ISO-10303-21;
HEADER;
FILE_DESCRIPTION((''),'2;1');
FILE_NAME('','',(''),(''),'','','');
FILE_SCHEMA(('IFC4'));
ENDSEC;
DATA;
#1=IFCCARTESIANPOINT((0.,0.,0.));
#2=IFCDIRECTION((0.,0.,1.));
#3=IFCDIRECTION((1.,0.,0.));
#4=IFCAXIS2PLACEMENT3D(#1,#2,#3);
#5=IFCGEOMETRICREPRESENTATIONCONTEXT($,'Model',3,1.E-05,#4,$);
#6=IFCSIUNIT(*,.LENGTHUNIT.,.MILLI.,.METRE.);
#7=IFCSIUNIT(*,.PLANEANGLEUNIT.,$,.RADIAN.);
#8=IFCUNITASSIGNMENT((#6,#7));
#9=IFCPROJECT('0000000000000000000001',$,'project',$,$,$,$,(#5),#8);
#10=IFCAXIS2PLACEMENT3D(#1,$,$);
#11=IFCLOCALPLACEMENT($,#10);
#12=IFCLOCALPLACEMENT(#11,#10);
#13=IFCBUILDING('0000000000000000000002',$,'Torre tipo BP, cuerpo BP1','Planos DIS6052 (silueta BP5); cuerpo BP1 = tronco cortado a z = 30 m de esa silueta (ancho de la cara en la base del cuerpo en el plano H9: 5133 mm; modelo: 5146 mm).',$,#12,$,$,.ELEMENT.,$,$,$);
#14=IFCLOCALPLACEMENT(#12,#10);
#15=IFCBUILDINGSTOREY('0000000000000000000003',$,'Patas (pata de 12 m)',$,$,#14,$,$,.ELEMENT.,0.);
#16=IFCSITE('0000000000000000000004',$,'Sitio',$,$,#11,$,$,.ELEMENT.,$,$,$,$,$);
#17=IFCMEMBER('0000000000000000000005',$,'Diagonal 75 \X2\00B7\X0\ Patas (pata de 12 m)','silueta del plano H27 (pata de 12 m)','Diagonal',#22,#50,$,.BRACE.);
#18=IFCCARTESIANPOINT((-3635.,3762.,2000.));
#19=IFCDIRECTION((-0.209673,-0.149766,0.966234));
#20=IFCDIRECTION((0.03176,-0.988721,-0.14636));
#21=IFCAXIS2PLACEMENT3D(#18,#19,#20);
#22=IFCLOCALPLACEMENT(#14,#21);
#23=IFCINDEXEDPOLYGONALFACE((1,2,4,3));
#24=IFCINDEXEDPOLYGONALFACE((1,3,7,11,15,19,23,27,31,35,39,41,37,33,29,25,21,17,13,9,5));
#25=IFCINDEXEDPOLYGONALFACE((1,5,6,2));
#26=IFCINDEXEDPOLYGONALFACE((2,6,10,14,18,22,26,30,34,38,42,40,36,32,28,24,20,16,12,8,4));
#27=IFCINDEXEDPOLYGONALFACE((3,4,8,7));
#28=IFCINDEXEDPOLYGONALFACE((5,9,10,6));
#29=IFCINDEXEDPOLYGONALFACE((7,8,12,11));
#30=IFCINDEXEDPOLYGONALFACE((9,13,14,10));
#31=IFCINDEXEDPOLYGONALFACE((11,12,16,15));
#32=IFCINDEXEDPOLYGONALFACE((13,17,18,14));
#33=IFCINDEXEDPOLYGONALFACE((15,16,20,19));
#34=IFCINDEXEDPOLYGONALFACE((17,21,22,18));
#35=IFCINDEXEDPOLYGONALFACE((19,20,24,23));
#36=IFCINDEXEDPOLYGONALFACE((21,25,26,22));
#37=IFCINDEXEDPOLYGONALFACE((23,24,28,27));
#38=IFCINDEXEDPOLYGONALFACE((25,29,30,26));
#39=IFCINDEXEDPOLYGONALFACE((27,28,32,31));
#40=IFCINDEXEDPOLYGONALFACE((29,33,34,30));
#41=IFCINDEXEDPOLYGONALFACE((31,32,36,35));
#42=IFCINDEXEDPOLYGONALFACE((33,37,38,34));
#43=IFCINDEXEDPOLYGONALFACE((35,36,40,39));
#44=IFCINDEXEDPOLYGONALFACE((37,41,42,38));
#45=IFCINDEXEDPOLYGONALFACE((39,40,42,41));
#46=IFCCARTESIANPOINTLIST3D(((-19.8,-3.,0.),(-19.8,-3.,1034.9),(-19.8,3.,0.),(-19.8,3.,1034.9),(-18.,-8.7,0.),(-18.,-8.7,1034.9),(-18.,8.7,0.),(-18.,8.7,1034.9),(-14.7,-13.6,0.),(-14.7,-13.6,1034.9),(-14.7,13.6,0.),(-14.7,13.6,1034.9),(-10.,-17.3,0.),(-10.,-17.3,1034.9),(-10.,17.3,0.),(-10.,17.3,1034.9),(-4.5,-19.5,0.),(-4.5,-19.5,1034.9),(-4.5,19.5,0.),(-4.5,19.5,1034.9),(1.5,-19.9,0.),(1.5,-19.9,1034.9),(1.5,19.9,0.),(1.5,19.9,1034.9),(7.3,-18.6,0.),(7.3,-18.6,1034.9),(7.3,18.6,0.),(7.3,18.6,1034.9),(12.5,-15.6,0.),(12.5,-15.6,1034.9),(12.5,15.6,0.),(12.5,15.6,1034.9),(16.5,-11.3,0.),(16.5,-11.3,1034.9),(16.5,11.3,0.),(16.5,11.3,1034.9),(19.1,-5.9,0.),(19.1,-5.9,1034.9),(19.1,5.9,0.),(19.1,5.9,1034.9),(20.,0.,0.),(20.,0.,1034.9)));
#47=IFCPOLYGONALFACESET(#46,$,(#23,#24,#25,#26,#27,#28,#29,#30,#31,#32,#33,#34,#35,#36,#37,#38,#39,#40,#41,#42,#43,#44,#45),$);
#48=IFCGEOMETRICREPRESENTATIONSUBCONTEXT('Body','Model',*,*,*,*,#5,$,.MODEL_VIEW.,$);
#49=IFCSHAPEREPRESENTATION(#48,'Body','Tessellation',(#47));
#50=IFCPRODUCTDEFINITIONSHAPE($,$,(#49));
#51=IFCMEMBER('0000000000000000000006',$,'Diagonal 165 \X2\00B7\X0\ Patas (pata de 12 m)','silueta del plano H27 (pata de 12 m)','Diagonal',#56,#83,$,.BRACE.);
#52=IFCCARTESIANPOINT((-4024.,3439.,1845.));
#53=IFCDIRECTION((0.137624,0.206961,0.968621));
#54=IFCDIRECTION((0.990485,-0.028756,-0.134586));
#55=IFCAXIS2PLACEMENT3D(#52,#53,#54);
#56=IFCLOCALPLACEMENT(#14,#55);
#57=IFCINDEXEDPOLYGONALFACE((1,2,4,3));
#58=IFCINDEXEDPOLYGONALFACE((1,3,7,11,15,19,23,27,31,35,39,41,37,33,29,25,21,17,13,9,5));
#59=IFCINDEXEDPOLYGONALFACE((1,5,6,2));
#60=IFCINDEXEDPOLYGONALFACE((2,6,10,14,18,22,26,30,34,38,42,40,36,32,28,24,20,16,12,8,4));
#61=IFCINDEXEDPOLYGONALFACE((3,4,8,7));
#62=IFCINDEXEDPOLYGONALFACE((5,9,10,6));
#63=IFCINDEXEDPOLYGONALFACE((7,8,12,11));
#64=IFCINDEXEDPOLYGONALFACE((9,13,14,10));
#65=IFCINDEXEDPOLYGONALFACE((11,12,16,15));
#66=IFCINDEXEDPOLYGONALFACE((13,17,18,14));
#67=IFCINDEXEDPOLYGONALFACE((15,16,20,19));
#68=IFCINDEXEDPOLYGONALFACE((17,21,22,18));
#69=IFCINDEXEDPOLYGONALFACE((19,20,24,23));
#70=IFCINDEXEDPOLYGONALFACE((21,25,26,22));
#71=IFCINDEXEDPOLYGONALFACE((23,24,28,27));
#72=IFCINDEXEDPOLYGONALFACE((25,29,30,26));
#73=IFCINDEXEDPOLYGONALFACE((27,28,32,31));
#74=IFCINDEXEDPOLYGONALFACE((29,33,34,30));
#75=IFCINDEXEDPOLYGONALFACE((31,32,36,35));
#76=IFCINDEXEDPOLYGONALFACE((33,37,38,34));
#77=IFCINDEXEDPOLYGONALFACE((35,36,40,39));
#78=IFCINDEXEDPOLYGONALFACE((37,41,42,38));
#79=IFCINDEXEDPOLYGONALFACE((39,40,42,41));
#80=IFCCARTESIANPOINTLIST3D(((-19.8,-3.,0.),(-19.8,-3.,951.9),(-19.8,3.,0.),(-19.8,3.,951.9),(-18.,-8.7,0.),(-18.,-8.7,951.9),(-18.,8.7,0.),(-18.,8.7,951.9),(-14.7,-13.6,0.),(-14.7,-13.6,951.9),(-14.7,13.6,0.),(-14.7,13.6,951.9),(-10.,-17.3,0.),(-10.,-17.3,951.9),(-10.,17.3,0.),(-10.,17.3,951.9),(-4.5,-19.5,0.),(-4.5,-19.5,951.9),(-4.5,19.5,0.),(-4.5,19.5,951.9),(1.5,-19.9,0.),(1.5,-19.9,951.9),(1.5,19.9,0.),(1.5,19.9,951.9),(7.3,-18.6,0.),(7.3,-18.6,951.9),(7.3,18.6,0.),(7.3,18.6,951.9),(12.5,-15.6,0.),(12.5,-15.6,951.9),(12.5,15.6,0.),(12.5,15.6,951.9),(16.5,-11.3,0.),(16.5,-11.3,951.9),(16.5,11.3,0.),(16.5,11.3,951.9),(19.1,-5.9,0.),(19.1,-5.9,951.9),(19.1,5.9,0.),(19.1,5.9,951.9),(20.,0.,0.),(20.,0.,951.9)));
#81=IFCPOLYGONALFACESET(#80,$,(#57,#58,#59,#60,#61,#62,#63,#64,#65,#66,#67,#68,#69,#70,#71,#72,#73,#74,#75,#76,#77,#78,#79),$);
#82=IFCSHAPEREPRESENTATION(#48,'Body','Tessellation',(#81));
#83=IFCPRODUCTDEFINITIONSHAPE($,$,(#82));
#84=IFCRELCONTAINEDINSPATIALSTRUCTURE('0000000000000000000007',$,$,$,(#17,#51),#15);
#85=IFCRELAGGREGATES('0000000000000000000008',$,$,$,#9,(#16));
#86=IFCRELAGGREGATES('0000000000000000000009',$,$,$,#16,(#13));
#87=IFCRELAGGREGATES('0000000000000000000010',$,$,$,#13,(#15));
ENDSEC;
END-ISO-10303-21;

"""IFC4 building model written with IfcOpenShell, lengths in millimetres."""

from ifc_helpers import new_model, si_unit, frame, origin, origin_with_axes, place, context, subcontext, project, spatial, circle, extrude, element, save


model = new_model("IFC4")

# Units and contexts
model_context = context("Model", 3, precision=1e-05, world=origin_with_axes())
body_context = subcontext(model_context, "Body", "Model", "MODEL_VIEW")
ifc_project = project(units=[si_unit("LENGTHUNIT", "METRE", prefix="MILLI"), si_unit("PLANEANGLEUNIT", "RADIAN")], contexts=[model_context])

# Site, building, storey
site_placement = place(None, origin())
site = spatial("IfcSite", under=ifc_project, at=site_placement, Name="Sitio", CompositionType="ELEMENT")
building_placement = place(site_placement, origin())
building = spatial("IfcBuilding", under=site, at=building_placement, Name="Torre tipo BP, cuerpo BP1", Description="Planos DIS6052 (silueta BP5); cuerpo BP1 = tronco cortado a z = 30 m de esa silueta (ancho de la cara en la base del cuerpo en el plano H9: 5133 mm; modelo: 5146 mm).", CompositionType="ELEMENT")
storey_placement = place(building_placement, origin())
storey = spatial("IfcBuildingStorey", under=building, at=storey_placement, Name="Patas (pata de 12 m)", CompositionType="ELEMENT", Elevation=0.0)

# Members
member_1_placement = place(storey_placement, frame((-3635.0, 3762.0, 2000.0), z_axis=(-0.209673, -0.149766, 0.966234), x_axis=(0.03176, -0.988721, -0.14636)))
element("IfcMember", 1, at=member_1_placement, inside=storey, Name="Diagonal 75 · Patas (pata de 12 m)", Description="silueta del plano H27 (pata de 12 m)", ObjectType="Diagonal", PredefinedType="BRACE", context=body_context, shape_type="SweptSolid", body=[
    extrude(circle(Radius=20.0), None, (0.0, 0.0, 1.0), 1034.9),
])
member_2_placement = place(storey_placement, frame((-4024.0, 3439.0, 1845.0), z_axis=(0.137624, 0.206961, 0.968621), x_axis=(0.990485, -0.028756, -0.134586)))
element("IfcMember", 2, at=member_2_placement, inside=storey, Name="Diagonal 165 · Patas (pata de 12 m)", Description="silueta del plano H27 (pata de 12 m)", ObjectType="Diagonal", PredefinedType="BRACE", context=body_context, shape_type="SweptSolid", body=[
    extrude(circle(Radius=20.0), None, (0.0, 0.0, 1.0), 951.9),
])

save(model, "model.ifc")
